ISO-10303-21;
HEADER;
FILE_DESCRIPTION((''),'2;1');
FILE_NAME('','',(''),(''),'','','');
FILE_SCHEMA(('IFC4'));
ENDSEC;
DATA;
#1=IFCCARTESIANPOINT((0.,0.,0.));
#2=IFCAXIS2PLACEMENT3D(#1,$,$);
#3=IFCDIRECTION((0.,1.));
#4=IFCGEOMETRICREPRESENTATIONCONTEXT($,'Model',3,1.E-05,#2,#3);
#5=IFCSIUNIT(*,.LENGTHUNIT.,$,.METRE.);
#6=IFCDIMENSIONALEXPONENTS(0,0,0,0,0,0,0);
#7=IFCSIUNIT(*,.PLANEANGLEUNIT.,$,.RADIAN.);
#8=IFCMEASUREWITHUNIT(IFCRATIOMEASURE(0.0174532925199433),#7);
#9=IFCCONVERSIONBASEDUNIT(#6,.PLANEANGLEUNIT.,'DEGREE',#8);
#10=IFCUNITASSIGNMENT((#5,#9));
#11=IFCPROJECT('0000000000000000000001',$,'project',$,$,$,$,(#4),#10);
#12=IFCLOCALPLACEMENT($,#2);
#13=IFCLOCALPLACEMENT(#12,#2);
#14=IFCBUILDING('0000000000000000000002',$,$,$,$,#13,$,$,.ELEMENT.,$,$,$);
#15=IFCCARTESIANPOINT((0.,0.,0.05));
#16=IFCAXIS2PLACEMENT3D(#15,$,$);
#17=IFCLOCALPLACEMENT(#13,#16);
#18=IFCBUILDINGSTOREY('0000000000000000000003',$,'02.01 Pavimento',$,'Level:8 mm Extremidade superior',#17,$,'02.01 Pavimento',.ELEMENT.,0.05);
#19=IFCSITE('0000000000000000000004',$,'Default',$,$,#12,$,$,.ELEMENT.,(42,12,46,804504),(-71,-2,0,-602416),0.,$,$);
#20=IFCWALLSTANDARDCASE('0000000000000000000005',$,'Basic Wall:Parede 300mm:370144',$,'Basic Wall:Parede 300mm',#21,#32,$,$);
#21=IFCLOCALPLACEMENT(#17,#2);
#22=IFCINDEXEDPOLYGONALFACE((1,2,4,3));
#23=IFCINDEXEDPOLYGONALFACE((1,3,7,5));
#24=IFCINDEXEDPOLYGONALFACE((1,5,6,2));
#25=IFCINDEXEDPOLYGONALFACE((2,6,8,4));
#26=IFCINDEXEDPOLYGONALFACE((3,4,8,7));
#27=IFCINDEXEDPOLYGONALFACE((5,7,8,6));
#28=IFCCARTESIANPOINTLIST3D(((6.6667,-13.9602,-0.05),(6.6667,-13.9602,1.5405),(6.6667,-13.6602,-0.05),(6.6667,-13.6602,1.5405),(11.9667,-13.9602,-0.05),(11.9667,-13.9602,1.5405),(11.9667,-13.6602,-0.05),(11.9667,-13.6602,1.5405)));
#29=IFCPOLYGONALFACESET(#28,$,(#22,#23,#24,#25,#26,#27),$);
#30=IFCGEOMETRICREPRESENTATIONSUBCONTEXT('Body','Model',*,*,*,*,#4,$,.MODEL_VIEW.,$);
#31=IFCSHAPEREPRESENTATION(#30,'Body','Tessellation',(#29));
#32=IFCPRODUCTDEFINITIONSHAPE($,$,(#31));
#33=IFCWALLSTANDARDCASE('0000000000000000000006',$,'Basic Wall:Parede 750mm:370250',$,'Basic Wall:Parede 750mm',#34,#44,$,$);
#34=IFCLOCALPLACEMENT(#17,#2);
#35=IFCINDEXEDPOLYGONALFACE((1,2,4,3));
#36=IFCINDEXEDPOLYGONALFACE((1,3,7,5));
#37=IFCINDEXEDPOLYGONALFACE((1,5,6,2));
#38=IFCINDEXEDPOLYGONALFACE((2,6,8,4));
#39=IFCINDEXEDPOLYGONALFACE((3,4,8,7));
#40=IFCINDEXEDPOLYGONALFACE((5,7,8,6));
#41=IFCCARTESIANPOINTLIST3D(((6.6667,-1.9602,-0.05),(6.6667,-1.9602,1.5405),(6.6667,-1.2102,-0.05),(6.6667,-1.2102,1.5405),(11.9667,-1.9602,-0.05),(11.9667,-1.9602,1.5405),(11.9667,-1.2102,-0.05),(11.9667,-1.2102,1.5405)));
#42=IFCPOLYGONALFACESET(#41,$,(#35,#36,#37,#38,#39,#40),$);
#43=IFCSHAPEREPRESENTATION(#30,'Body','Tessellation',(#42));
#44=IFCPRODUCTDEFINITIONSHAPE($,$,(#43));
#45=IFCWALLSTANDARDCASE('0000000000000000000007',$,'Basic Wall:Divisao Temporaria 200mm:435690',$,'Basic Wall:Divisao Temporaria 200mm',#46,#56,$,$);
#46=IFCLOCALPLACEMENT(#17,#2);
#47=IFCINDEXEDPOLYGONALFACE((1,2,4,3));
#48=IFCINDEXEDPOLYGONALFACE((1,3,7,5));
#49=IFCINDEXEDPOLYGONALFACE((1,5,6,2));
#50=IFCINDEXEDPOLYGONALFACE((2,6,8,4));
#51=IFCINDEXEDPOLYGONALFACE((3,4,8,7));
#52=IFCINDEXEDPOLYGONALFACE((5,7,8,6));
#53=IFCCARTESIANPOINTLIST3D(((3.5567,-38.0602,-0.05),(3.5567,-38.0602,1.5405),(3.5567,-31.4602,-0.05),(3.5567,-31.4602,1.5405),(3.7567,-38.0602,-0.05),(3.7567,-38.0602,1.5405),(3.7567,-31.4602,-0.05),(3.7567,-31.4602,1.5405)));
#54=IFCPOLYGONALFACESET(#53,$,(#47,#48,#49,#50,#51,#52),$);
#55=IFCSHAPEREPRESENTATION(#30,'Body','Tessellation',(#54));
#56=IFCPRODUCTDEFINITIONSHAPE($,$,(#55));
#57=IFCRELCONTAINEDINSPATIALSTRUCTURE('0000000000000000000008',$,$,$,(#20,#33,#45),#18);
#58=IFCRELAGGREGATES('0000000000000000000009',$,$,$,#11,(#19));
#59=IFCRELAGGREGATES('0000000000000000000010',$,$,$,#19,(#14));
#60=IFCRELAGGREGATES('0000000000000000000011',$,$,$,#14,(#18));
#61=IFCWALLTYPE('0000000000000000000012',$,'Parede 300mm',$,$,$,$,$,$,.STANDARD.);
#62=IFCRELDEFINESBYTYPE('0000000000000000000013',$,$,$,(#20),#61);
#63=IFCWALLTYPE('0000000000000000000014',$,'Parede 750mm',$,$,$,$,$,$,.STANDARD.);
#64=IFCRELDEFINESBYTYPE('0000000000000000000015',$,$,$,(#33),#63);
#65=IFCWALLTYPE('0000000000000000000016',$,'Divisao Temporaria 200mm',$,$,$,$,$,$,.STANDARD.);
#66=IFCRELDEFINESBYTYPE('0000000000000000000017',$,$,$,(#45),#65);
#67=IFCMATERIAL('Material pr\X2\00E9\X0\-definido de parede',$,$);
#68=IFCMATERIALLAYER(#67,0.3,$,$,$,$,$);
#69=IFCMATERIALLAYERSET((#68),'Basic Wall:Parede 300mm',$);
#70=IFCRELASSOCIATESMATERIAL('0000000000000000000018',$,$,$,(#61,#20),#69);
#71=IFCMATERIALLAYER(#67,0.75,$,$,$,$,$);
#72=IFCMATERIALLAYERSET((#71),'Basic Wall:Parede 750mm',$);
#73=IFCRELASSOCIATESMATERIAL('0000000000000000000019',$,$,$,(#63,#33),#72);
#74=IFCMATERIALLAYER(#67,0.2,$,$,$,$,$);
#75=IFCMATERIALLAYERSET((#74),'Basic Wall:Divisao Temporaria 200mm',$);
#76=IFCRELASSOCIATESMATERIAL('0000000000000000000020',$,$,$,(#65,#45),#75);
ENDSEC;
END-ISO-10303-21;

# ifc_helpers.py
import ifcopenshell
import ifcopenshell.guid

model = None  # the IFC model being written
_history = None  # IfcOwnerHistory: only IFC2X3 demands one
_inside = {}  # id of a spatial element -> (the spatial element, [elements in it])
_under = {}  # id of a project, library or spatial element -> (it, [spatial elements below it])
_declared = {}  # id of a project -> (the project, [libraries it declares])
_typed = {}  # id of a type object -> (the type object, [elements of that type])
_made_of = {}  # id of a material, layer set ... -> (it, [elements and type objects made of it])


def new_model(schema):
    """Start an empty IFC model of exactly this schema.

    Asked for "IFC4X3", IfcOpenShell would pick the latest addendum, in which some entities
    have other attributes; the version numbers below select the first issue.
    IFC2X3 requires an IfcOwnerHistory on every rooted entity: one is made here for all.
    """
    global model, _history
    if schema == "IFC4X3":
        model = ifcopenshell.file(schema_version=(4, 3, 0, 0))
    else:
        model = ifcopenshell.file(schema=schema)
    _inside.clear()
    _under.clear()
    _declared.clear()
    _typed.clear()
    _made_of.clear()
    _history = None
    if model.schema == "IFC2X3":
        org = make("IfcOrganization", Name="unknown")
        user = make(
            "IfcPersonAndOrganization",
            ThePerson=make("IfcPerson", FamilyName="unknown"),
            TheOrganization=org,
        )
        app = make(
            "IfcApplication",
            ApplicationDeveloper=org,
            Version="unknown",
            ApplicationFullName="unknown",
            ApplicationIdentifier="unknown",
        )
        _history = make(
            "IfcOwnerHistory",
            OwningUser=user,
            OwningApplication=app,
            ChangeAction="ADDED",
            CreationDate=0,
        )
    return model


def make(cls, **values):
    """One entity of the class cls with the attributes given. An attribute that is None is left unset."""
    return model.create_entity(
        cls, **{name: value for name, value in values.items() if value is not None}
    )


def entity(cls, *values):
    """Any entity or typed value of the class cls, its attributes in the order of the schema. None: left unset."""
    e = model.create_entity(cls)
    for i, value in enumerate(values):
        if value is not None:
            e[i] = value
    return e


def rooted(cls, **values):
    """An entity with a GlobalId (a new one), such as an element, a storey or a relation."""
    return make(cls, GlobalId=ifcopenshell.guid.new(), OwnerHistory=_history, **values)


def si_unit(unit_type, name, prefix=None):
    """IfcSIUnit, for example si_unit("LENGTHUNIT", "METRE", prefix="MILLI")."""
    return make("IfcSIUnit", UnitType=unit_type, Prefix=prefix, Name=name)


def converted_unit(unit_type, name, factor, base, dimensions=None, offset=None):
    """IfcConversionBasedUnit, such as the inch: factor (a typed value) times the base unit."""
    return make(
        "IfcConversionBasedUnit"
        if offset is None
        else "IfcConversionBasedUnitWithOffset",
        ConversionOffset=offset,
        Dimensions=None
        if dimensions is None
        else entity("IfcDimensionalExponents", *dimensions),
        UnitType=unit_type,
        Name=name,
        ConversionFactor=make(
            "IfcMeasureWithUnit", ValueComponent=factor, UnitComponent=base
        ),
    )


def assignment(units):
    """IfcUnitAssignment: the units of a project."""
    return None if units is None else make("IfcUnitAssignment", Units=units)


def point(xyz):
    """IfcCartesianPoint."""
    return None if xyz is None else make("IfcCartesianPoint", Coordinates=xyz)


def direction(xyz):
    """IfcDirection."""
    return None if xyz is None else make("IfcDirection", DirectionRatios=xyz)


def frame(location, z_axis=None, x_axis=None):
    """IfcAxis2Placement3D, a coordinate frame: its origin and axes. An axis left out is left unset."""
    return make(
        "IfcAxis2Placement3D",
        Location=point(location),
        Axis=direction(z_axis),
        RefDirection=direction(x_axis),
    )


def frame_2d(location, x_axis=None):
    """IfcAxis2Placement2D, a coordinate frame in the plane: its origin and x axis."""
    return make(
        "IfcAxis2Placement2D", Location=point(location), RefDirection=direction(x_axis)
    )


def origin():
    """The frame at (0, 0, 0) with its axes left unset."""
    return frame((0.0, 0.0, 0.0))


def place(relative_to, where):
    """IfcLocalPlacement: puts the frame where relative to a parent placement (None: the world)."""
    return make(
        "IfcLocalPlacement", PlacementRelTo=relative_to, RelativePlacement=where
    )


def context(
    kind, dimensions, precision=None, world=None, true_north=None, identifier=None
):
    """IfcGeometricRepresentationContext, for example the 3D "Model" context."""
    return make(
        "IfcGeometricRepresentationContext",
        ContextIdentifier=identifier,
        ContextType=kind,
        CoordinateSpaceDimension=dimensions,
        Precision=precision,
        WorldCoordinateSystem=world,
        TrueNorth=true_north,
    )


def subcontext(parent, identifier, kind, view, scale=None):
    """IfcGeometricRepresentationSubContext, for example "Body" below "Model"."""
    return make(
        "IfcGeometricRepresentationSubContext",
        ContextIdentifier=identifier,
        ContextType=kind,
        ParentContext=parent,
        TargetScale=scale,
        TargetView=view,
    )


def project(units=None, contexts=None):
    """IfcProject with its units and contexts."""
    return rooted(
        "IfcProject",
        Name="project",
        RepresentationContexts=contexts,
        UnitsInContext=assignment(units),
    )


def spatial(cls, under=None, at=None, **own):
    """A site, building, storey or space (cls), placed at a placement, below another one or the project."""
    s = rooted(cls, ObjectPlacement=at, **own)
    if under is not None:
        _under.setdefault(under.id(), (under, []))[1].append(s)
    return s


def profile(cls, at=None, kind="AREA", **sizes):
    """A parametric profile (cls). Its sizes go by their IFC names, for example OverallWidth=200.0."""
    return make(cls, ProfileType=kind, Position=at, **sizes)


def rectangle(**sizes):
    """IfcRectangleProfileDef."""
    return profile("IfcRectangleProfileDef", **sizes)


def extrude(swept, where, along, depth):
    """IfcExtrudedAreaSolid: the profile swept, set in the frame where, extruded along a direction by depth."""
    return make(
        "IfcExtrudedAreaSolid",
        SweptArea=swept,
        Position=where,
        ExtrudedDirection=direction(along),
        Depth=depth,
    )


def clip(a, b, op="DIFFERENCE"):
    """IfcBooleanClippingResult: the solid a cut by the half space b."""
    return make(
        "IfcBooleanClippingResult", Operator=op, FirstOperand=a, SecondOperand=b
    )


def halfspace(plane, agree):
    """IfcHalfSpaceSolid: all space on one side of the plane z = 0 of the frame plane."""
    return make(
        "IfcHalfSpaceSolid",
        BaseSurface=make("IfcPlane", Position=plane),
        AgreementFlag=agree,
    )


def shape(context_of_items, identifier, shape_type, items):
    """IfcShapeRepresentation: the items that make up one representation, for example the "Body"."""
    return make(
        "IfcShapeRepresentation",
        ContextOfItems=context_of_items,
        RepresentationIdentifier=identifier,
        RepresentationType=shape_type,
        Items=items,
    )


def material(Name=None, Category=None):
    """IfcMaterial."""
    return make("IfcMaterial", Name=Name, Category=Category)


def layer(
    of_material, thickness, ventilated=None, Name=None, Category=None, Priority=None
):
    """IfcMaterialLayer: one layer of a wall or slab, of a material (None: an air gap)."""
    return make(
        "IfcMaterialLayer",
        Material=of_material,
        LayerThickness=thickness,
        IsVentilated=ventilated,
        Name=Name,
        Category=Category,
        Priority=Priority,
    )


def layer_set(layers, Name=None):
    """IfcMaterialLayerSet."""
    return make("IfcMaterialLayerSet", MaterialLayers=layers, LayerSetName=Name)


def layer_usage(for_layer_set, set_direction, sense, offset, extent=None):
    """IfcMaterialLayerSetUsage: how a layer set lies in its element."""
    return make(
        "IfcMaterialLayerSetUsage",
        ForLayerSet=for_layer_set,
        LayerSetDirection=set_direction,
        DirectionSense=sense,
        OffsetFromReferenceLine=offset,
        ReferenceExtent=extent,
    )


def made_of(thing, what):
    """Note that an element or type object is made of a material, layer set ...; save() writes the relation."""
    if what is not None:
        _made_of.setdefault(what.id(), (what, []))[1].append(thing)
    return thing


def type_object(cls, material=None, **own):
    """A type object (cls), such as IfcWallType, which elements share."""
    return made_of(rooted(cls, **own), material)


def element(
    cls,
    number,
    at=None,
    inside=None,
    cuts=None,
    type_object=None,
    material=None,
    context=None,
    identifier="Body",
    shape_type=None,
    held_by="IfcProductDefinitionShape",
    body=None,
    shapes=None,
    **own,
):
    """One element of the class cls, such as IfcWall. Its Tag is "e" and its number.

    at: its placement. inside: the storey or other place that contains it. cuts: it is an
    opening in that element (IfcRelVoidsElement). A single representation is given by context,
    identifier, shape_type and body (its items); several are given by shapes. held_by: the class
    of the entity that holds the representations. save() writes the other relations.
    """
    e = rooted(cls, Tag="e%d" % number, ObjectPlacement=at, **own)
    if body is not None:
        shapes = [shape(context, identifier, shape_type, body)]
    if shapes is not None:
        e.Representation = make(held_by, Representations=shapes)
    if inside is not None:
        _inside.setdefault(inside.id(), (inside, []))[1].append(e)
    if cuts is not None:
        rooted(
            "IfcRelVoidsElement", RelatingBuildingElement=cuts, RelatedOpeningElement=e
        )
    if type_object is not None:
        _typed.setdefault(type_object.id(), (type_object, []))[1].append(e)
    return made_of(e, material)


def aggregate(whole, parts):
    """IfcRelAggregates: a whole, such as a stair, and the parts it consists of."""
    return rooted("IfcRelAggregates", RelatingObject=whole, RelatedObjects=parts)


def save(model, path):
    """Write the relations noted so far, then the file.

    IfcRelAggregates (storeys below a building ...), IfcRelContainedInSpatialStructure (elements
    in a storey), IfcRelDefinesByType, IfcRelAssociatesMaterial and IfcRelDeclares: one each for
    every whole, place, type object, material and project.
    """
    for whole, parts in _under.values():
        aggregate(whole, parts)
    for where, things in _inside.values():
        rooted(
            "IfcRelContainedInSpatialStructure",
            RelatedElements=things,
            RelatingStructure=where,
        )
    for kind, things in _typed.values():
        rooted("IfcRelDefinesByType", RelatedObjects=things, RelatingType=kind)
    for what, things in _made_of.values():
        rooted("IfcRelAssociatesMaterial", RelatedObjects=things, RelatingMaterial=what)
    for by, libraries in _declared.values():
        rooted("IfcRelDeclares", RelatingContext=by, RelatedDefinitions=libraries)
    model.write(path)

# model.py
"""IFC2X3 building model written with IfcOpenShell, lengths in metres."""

from ifc_helpers import new_model, entity, si_unit, converted_unit, direction, frame, frame_2d, origin, place, context, subcontext, project, spatial, rectangle, extrude, clip, halfspace, material, layer, layer_set, layer_usage, type_object, element, save


model = new_model("IFC2X3")

# Units and contexts
model_context = context("Model", 3, precision=1e-05, world=origin(), true_north=direction((0.0, 1.0)))
body_context = subcontext(model_context, "Body", "Model", "MODEL_VIEW")
ifc_project = project(units=[si_unit("LENGTHUNIT", "METRE"), converted_unit("PLANEANGLEUNIT", "DEGREE", entity("IfcRatioMeasure", 0.0174532925199433), si_unit("PLANEANGLEUNIT", "RADIAN"), dimensions=[0, 0, 0, 0, 0, 0, 0])], contexts=[model_context])

# Site, building, storey
site_placement = place(None, origin())
site = spatial("IfcSite", under=ifc_project, at=site_placement, Name="Default", CompositionType="ELEMENT", RefLatitude=(42, 12, 46, 804504), RefLongitude=(-71, -2, 0, -602416), RefElevation=0.0)
building_placement = place(site_placement, origin())
building = spatial("IfcBuilding", under=site, at=building_placement, CompositionType="ELEMENT")
storey_placement = place(building_placement, frame((0.0, 0.0, 0.05)))
storey = spatial("IfcBuildingStorey", under=building, at=storey_placement, Name="02.01 Pavimento", ObjectType="Level:8 mm Extremidade superior", LongName="02.01 Pavimento", CompositionType="ELEMENT", Elevation=0.05)

# Shared definitions
ifc_material_1 = material(Name="Material pré-definido de parede")

# Walls
ifc_layer_1 = layer(ifc_material_1, 0.3)
ifc_layer_set_1 = layer_set([ifc_layer_1], Name="Basic Wall:Parede 300mm")
ifc_layer_usage_1 = layer_usage(ifc_layer_set_1, "AXIS2", "POSITIVE", -0.15)
wall_type_1 = type_object("IfcWallType", Name="Parede 300mm", PredefinedType="STANDARD", material=ifc_layer_set_1)
wall_1_placement = place(storey_placement, frame((6.6667, -13.8102, -0.05)))
element("IfcWallStandardCase", 1, at=wall_1_placement, inside=storey, type_object=wall_type_1, material=ifc_layer_usage_1, Name="Basic Wall:Parede 300mm:370144", ObjectType="Basic Wall:Parede 300mm", context=body_context, shape_type="Clipping", body=[
    clip(extrude(rectangle(XDim=0.3, YDim=5.3, at=frame_2d((2.65, 0.0), x_axis=(0.0, 1.0))), origin(), (0.0, 0.0, 1.0), 1.5905), halfspace(frame((0.0, 0.0, -0.05)), True)),
])
ifc_layer_2 = layer(ifc_material_1, 0.75)
ifc_layer_set_2 = layer_set([ifc_layer_2], Name="Basic Wall:Parede 750mm")
ifc_layer_usage_2 = layer_usage(ifc_layer_set_2, "AXIS2", "POSITIVE", -0.375)
wall_type_2 = type_object("IfcWallType", Name="Parede 750mm", PredefinedType="STANDARD", material=ifc_layer_set_2)
wall_2_placement = place(storey_placement, frame((6.6667, -1.5852, -0.05)))
element("IfcWallStandardCase", 2, at=wall_2_placement, inside=storey, type_object=wall_type_2, material=ifc_layer_usage_2, Name="Basic Wall:Parede 750mm:370250", ObjectType="Basic Wall:Parede 750mm", context=body_context, shape_type="Clipping", body=[
    clip(extrude(rectangle(XDim=0.75, YDim=5.3, at=frame_2d((2.65, 0.0), x_axis=(0.0, 1.0))), origin(), (0.0, 0.0, 1.0), 1.5905), halfspace(frame((0.0, 0.0, -0.05)), True)),
])
ifc_layer_3 = layer(ifc_material_1, 0.2)
ifc_layer_set_3 = layer_set([ifc_layer_3], Name="Basic Wall:Divisao Temporaria 200mm")
ifc_layer_usage_3 = layer_usage(ifc_layer_set_3, "AXIS2", "NEGATIVE", 0.1)
wall_type_3 = type_object("IfcWallType", Name="Divisao Temporaria 200mm", PredefinedType="STANDARD", material=ifc_layer_set_3)
wall_3_placement = place(storey_placement, frame((3.6567, -38.0602, -0.05), z_axis=(0.0, 0.0, 1.0), x_axis=(0.0, 1.0, 0.0)))
element("IfcWallStandardCase", 3, at=wall_3_placement, inside=storey, type_object=wall_type_3, material=ifc_layer_usage_3, Name="Basic Wall:Divisao Temporaria 200mm:435690", ObjectType="Basic Wall:Divisao Temporaria 200mm", context=body_context, shape_type="Clipping", body=[
    clip(extrude(rectangle(XDim=6.6, YDim=0.2, at=frame_2d((3.3, 0.0), x_axis=(-1.0, 0.0))), origin(), (0.0, 0.0, 1.0), 1.5905), halfspace(frame((0.0, 0.0, -0.05)), True)),
])

save(model, "model.ifc")
